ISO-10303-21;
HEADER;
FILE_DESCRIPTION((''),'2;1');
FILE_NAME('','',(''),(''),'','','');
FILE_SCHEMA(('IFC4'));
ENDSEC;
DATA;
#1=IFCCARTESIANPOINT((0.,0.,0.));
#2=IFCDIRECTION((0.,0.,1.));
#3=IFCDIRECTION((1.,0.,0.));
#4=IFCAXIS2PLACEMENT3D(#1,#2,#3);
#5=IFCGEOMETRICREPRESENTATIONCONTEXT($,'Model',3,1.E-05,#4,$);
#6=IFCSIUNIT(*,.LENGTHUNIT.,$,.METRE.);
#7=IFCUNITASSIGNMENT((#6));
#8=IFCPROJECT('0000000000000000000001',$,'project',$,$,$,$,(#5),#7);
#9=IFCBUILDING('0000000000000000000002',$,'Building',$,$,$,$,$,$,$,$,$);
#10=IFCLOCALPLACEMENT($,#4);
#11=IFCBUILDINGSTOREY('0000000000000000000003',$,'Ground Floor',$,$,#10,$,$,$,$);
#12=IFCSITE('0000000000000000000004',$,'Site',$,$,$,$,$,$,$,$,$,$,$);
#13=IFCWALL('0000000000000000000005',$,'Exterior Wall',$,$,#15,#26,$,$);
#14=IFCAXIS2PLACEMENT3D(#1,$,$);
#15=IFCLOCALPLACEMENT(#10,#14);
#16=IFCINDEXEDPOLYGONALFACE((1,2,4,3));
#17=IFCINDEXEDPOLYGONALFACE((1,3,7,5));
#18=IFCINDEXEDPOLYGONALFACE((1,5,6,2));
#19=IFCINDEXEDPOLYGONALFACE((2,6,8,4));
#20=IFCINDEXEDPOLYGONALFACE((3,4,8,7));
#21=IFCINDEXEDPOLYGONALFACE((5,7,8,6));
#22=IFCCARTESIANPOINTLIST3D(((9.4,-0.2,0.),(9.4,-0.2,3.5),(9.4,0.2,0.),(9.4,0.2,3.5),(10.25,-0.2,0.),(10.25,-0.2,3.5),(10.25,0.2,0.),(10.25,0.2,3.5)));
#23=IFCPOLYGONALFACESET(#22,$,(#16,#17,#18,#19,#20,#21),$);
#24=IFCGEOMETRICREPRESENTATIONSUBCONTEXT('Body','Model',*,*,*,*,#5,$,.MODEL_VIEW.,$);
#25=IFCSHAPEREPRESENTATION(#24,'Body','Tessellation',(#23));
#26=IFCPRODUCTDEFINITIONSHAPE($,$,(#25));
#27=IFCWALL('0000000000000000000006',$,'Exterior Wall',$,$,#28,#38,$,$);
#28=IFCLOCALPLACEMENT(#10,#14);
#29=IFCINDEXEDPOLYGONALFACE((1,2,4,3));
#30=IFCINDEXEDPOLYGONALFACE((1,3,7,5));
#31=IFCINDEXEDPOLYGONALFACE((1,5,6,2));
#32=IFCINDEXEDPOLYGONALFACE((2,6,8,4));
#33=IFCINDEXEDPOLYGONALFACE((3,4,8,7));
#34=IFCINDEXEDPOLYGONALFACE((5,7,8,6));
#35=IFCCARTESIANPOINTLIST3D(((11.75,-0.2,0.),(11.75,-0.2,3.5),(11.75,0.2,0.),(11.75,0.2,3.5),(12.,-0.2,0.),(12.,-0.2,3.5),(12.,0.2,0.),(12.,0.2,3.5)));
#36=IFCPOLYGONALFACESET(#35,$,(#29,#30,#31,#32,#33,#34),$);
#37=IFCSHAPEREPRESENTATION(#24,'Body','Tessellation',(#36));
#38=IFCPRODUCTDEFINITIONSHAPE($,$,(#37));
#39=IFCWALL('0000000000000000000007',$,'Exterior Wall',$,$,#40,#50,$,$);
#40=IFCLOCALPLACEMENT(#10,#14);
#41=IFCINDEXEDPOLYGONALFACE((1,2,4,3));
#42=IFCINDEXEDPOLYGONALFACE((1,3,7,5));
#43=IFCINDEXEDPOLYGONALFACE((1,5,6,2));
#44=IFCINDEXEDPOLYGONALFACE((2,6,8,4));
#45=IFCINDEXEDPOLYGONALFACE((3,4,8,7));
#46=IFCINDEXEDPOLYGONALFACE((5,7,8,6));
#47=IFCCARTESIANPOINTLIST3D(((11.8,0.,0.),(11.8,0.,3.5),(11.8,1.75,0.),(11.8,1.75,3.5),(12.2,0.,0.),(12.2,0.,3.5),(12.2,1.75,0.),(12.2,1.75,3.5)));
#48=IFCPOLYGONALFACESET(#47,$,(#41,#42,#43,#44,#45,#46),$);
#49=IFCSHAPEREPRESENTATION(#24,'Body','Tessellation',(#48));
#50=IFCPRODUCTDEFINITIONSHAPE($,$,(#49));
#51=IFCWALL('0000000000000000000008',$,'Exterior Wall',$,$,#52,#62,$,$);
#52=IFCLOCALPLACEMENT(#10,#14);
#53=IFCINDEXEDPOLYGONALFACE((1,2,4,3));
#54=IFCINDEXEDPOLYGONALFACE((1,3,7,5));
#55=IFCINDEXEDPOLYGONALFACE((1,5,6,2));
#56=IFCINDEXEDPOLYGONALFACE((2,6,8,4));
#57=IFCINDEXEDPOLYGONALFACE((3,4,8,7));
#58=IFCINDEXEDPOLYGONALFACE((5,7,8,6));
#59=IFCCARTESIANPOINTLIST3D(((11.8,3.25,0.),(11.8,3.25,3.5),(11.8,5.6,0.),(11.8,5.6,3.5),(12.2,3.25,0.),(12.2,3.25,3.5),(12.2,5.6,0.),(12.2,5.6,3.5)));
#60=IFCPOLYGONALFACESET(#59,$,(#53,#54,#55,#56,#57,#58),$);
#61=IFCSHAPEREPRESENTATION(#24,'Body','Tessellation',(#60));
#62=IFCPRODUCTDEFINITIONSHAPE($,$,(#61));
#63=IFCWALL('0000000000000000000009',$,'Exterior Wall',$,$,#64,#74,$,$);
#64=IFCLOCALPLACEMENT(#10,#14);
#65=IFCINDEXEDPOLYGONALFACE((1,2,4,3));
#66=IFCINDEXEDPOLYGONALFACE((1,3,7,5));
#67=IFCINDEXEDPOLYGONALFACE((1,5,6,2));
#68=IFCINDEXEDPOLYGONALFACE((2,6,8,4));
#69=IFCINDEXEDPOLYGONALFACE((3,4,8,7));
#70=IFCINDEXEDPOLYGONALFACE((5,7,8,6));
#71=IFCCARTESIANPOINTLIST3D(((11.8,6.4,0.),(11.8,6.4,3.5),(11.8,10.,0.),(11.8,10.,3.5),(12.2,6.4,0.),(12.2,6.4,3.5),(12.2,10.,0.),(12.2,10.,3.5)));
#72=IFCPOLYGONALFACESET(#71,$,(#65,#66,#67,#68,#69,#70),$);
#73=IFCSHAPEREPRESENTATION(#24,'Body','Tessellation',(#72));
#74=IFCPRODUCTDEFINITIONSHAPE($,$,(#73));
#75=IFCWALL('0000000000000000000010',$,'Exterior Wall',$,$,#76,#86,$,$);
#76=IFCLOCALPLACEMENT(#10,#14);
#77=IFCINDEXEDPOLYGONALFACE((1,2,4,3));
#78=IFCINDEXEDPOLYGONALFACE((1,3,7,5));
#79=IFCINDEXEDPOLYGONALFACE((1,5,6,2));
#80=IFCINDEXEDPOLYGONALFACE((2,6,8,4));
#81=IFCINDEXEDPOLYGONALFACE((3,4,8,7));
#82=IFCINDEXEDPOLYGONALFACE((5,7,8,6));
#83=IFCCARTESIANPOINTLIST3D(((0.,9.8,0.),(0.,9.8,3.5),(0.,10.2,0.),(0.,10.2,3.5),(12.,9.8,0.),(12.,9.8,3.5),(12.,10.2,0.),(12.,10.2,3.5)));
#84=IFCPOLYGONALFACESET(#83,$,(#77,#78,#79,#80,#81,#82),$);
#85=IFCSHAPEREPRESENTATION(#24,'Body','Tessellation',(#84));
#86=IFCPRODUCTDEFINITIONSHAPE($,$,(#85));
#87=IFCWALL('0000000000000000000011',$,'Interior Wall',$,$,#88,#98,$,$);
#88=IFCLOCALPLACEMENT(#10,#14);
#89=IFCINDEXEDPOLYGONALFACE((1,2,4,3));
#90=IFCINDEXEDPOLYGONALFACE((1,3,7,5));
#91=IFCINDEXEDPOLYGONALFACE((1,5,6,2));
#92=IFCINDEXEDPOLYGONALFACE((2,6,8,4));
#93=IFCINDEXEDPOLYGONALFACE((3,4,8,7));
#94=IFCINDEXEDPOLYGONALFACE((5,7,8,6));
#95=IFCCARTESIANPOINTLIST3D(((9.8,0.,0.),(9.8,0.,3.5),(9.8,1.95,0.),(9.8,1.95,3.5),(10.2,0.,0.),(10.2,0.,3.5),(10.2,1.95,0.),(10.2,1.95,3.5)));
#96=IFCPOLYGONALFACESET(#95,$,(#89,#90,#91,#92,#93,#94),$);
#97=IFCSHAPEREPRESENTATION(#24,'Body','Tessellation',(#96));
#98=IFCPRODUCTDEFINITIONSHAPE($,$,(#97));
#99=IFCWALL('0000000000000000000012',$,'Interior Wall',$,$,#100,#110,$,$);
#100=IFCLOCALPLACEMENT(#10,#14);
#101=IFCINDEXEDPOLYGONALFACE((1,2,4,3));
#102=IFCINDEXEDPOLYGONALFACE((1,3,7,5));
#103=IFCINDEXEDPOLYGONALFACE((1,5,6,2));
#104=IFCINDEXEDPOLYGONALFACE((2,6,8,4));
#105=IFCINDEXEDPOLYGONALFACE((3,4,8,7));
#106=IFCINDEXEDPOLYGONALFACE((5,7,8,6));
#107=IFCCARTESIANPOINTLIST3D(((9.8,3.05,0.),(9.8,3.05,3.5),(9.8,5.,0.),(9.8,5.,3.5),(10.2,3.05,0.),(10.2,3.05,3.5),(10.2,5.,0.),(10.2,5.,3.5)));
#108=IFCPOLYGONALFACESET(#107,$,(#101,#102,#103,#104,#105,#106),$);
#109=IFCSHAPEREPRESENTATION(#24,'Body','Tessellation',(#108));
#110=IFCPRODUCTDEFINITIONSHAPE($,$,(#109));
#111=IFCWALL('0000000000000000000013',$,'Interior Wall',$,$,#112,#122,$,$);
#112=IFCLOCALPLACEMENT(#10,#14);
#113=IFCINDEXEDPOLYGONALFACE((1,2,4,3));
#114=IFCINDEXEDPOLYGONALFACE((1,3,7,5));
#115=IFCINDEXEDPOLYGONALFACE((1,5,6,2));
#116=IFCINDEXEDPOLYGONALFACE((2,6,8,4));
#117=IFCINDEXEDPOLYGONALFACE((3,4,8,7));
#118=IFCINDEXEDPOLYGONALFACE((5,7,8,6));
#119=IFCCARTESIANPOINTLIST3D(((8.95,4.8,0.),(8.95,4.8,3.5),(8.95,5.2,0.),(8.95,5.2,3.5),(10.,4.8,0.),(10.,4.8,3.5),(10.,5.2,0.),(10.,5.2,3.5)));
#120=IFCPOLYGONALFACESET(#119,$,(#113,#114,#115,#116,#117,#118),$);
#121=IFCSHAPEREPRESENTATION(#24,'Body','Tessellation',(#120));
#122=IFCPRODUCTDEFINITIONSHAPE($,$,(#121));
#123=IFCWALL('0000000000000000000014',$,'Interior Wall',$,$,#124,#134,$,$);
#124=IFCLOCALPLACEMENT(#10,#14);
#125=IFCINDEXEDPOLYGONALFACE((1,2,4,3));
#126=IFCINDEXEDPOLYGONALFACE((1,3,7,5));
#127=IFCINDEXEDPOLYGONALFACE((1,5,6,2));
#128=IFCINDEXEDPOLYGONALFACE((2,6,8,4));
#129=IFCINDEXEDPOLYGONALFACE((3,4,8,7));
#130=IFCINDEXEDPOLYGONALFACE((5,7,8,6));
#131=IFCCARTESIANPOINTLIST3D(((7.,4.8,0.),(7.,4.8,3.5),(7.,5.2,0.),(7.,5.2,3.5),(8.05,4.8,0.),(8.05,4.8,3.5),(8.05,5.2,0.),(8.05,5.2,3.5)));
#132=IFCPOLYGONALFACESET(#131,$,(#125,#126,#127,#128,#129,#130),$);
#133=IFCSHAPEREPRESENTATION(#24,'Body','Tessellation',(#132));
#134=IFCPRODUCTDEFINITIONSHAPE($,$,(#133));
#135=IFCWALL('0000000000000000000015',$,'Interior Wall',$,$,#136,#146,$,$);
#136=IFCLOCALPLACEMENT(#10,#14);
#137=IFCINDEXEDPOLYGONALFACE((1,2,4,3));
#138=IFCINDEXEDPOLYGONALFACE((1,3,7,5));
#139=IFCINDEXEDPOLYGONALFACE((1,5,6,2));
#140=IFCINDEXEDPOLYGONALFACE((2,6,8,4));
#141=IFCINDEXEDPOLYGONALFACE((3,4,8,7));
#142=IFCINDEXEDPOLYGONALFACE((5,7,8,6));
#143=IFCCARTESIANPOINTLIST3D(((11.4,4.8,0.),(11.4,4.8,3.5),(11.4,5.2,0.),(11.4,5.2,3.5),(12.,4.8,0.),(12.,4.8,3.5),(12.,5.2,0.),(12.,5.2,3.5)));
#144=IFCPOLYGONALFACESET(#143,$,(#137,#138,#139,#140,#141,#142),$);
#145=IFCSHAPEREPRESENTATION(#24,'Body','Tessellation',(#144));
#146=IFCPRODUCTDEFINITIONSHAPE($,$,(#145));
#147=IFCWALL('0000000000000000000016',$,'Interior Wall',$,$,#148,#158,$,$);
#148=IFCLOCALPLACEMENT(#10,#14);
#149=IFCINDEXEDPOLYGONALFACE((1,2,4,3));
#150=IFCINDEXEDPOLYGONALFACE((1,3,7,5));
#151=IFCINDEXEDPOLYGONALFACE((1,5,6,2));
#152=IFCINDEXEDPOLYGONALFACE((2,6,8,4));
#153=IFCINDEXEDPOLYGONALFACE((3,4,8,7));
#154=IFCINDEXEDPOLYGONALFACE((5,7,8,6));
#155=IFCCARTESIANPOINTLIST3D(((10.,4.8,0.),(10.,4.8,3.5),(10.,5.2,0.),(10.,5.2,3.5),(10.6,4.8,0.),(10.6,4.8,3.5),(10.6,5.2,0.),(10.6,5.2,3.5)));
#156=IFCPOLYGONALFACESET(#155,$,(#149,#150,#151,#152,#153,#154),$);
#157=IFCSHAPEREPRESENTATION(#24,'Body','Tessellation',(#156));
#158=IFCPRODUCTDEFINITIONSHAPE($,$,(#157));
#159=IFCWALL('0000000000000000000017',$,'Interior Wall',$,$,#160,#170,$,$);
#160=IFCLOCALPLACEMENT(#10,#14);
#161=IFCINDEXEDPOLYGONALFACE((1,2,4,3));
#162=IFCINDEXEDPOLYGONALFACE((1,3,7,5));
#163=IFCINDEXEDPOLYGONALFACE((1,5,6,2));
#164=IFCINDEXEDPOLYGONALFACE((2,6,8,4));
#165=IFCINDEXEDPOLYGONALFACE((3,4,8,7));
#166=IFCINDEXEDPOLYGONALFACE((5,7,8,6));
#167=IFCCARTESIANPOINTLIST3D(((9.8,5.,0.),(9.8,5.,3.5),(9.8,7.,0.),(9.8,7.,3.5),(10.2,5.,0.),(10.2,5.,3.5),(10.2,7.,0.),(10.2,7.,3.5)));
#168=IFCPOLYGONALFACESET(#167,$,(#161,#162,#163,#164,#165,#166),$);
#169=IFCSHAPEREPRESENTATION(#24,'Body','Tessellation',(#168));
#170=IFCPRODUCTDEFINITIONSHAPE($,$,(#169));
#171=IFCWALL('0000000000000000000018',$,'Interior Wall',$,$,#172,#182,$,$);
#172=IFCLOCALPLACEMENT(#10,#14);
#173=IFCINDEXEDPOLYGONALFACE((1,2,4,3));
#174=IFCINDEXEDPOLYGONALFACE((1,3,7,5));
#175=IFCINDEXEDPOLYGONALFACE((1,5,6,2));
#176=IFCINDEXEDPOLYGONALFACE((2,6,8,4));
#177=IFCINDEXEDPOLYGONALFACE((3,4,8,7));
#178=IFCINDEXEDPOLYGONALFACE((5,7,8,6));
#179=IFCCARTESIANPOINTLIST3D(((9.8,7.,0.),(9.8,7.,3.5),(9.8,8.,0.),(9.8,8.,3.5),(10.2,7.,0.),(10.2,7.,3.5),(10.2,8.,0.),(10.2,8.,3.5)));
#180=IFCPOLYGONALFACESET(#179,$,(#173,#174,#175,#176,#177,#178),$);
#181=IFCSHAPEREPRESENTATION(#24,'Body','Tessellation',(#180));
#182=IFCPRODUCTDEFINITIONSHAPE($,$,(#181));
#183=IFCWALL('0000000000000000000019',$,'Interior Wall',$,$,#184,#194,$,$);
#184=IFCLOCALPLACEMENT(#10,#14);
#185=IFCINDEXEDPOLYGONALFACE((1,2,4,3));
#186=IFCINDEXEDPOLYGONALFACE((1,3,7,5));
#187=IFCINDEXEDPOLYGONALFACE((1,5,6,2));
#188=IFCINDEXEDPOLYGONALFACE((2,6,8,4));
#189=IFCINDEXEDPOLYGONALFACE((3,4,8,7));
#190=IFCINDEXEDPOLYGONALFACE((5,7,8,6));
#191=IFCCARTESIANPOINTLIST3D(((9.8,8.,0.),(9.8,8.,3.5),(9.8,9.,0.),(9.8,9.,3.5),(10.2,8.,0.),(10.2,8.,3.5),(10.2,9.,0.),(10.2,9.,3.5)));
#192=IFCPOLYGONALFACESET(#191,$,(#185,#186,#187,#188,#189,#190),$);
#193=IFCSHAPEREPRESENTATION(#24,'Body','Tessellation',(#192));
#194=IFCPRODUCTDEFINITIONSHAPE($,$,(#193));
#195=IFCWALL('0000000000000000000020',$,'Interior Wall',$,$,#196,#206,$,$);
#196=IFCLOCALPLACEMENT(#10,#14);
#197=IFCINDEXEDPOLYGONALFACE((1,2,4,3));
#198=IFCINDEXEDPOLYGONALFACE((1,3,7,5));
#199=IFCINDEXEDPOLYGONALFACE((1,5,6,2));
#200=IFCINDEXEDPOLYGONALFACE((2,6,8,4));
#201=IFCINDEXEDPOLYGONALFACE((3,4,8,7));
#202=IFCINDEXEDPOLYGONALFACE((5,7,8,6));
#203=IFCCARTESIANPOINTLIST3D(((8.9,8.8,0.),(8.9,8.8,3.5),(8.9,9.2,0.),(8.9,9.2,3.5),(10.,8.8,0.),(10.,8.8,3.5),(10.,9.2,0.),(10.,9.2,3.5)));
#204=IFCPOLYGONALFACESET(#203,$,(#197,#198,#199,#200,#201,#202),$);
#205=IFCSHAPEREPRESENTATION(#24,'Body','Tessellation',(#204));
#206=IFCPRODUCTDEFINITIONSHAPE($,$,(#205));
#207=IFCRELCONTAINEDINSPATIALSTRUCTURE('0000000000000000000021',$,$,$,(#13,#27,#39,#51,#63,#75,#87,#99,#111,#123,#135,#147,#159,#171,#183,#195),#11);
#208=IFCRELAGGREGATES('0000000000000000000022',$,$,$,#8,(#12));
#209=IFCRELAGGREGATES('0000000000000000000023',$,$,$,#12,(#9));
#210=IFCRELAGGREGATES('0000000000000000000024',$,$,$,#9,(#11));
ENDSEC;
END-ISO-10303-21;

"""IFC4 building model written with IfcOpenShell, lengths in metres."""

from ifc_helpers import new_model, si_unit, frame, origin_with_axes, place, context, subcontext, project, spatial, indexed_curve, outline, extrude, element, save


model = new_model("IFC4")

# Units and contexts
model_context = context("Model", 3, precision=1e-05, world=origin_with_axes())
body_context = subcontext(model_context, "Body", "Model", "MODEL_VIEW")
ifc_project = project(units=[si_unit("LENGTHUNIT", "METRE")], contexts=[model_context])

# Site, building, storey
site = spatial("IfcSite", under=ifc_project, Name="Site")
building = spatial("IfcBuilding", under=site, Name="Building")
storey_placement = place(None, origin_with_axes())
storey = spatial("IfcBuildingStorey", under=building, at=storey_placement, Name="Ground Floor")

# Walls
wall_1_placement = place(storey_placement, frame((9.4, 0.0, 0.0), z_axis=(0.0, 0.0, 1.0), x_axis=(1.0, 0.0, 0.0)))
element("IfcWall", 1, at=wall_1_placement, inside=storey, Name="Exterior Wall", context=body_context, shape_type="SweptSolid", body=[
    extrude(outline(indexed_curve([(0.0, 0.0), (0.0, 0.4), (0.85, 0.4), (0.85, 0.0), (0.0, 0.0)], self_intersect=False)), frame((0.0, -0.2, 0.0), z_axis=(0.0, 0.0, 1.0), x_axis=(1.0, 0.0, 0.0)), (0.0, 0.0, 1.0), 3.5),
])
wall_2_placement = place(storey_placement, frame((11.75, 0.0, 0.0), z_axis=(0.0, 0.0, 1.0), x_axis=(1.0, 0.0, 0.0)))
element("IfcWall", 2, at=wall_2_placement, inside=storey, Name="Exterior Wall", context=body_context, shape_type="SweptSolid", body=[
    extrude(outline(indexed_curve([(0.0, 0.0), (0.0, 0.4), (0.25, 0.4), (0.25, 0.0), (0.0, 0.0)], self_intersect=False)), frame((0.0, -0.2, 0.0), z_axis=(0.0, 0.0, 1.0), x_axis=(1.0, 0.0, 0.0)), (0.0, 0.0, 1.0), 3.5),
])
wall_3_placement = place(storey_placement, frame((12.0, 0.0, 0.0), z_axis=(0.0, 0.0, 1.0), x_axis=(0.0, 1.0, 0.0)))
element("IfcWall", 3, at=wall_3_placement, inside=storey, Name="Exterior Wall", context=body_context, shape_type="SweptSolid", body=[
    extrude(outline(indexed_curve([(0.0, 0.0), (0.0, 0.4), (1.75, 0.4), (1.75, 0.0), (0.0, 0.0)], self_intersect=False)), frame((0.0, -0.2, 0.0), z_axis=(0.0, 0.0, 1.0), x_axis=(1.0, 0.0, 0.0)), (0.0, 0.0, 1.0), 3.5),
])
wall_4_placement = place(storey_placement, frame((12.0, 3.25, 0.0), z_axis=(0.0, 0.0, 1.0), x_axis=(0.0, 1.0, 0.0)))
element("IfcWall", 4, at=wall_4_placement, inside=storey, Name="Exterior Wall", context=body_context, shape_type="SweptSolid", body=[
    extrude(outline(indexed_curve([(0.0, 0.0), (0.0, 0.4), (2.35, 0.4), (2.35, 0.0), (0.0, 0.0)], self_intersect=False)), frame((0.0, -0.2, 0.0), z_axis=(0.0, 0.0, 1.0), x_axis=(1.0, 0.0, 0.0)), (0.0, 0.0, 1.0), 3.5),
])
wall_5_placement = place(storey_placement, frame((12.0, 6.4, 0.0), z_axis=(0.0, 0.0, 1.0), x_axis=(0.0, 1.0, 0.0)))
element("IfcWall", 5, at=wall_5_placement, inside=storey, Name="Exterior Wall", context=body_context, shape_type="SweptSolid", body=[
    extrude(outline(indexed_curve([(0.0, 0.0), (0.0, 0.4), (3.6, 0.4), (3.6, 0.0), (0.0, 0.0)], self_intersect=False)), frame((0.0, -0.2, 0.0), z_axis=(0.0, 0.0, 1.0), x_axis=(1.0, 0.0, 0.0)), (0.0, 0.0, 1.0), 3.5),
])
wall_6_placement = place(storey_placement, frame((12.0, 10.0, 0.0), z_axis=(0.0, 0.0, 1.0), x_axis=(-1.0, 0.0, 0.0)))
element("IfcWall", 6, at=wall_6_placement, inside=storey, Name="Exterior Wall", context=body_context, shape_type="SweptSolid", body=[
    extrude(outline(indexed_curve([(0.0, 0.0), (0.0, 0.4), (12.0, 0.4), (12.0, 0.0), (0.0, 0.0)], self_intersect=False)), frame((0.0, -0.2, 0.0), z_axis=(0.0, 0.0, 1.0), x_axis=(1.0, 0.0, 0.0)), (0.0, 0.0, 1.0), 3.5),
])
wall_7_placement = place(storey_placement, frame((10.0, 0.0, 0.0), z_axis=(0.0, 0.0, 1.0), x_axis=(0.0, 1.0, 0.0)))
element("IfcWall", 7, at=wall_7_placement, inside=storey, Name="Interior Wall", context=body_context, shape_type="SweptSolid", body=[
    extrude(outline(indexed_curve([(0.0, 0.0), (0.0, 0.4), (1.95, 0.4), (1.95, 0.0), (0.0, 0.0)], self_intersect=False)), frame((0.0, -0.2, 0.0), z_axis=(0.0, 0.0, 1.0), x_axis=(1.0, 0.0, 0.0)), (0.0, 0.0, 1.0), 3.5),
])
wall_8_placement = place(storey_placement, frame((10.0, 3.05, 0.0), z_axis=(0.0, 0.0, 1.0), x_axis=(0.0, 1.0, 0.0)))
element("IfcWall", 8, at=wall_8_placement, inside=storey, Name="Interior Wall", context=body_context, shape_type="SweptSolid", body=[
    extrude(outline(indexed_curve([(0.0, 0.0), (0.0, 0.4), (1.95, 0.4), (1.95, 0.0), (0.0, 0.0)], self_intersect=False)), frame((0.0, -0.2, 0.0), z_axis=(0.0, 0.0, 1.0), x_axis=(1.0, 0.0, 0.0)), (0.0, 0.0, 1.0), 3.5),
])
for number, where, z_axis, x_axis, name in (
    (9, (10.0, 5.0, 0.0), (0.0, 0.0, 1.0), (-1.0, 0.0, 0.0), "Interior Wall"),
    (10, (8.05, 5.0, 0.0), (0.0, 0.0, 1.0), (-1.0, 0.0, 0.0), "Interior Wall"),
):
    element("IfcWall", number, at=place(storey_placement, frame(where, z_axis=z_axis, x_axis=x_axis)), inside=storey, Name=name, context=body_context, shape_type="SweptSolid", body=[
        extrude(outline(indexed_curve([(0.0, 0.0), (0.0, 0.4), (1.05, 0.4), (1.05, 0.0), (0.0, 0.0)], self_intersect=False)), frame((0.0, -0.2, 0.0), z_axis=(0.0, 0.0, 1.0), x_axis=(1.0, 0.0, 0.0)), (0.0, 0.0, 1.0), 3.5),
    ])
for number, where, z_axis, x_axis, name in (
    (11, (12.0, 5.0, 0.0), (0.0, 0.0, 1.0), (-1.0, 0.0, 0.0), "Interior Wall"),
    (12, (10.6, 5.0, 0.0), (0.0, 0.0, 1.0), (-1.0, 0.0, 0.0), "Interior Wall"),
):
    element("IfcWall", number, at=place(storey_placement, frame(where, z_axis=z_axis, x_axis=x_axis)), inside=storey, Name=name, context=body_context, shape_type="SweptSolid", body=[
        extrude(outline(indexed_curve([(0.0, 0.0), (0.0, 0.4), (0.6, 0.4), (0.6, 0.0), (0.0, 0.0)], self_intersect=False)), frame((0.0, -0.2, 0.0), z_axis=(0.0, 0.0, 1.0), x_axis=(1.0, 0.0, 0.0)), (0.0, 0.0, 1.0), 3.5),
    ])
wall_9_placement = place(storey_placement, frame((10.0, 5.0, 0.0), z_axis=(0.0, 0.0, 1.0), x_axis=(0.0, 1.0, 0.0)))
element("IfcWall", 13, at=wall_9_placement, inside=storey, Name="Interior Wall", context=body_context, shape_type="SweptSolid", body=[
    extrude(outline(indexed_curve([(0.0, 0.0), (0.0, 0.4), (2.0, 0.4), (2.0, 0.0), (0.0, 0.0)], self_intersect=False)), frame((0.0, -0.2, 0.0), z_axis=(0.0, 0.0, 1.0), x_axis=(1.0, 0.0, 0.0)), (0.0, 0.0, 1.0), 3.5),
])
for number, where, z_axis, x_axis, name in (
    (14, (10.0, 7.0, 0.0), (0.0, 0.0, 1.0), (0.0, 1.0, 0.0), "Interior Wall"),
    (15, (10.0, 8.0, 0.0), (0.0, 0.0, 1.0), (0.0, 1.0, 0.0), "Interior Wall"),
):
    element("IfcWall", number, at=place(storey_placement, frame(where, z_axis=z_axis, x_axis=x_axis)), inside=storey, Name=name, context=body_context, shape_type="SweptSolid", body=[
        extrude(outline(indexed_curve([(0.0, 0.0), (0.0, 0.4), (1.0, 0.4), (1.0, 0.0), (0.0, 0.0)], self_intersect=False)), frame((0.0, -0.2, 0.0), z_axis=(0.0, 0.0, 1.0), x_axis=(1.0, 0.0, 0.0)), (0.0, 0.0, 1.0), 3.5),
    ])
for number, where, z_axis, x_axis, name in (
    (16, (10.0, 9.0, 0.0), (0.0, 0.0, 1.0), (-1.0, 0.0, 0.0), "Interior Wall"),
):
    element("IfcWall", number, at=place(storey_placement, frame(where, z_axis=z_axis, x_axis=x_axis)), inside=storey, Name=name, context=body_context, shape_type="SweptSolid", body=[
        extrude(outline(indexed_curve([(0.0, 0.0), (0.0, 0.4), (1.1, 0.4), (1.1, 0.0), (0.0, 0.0)], self_intersect=False)), frame((0.0, -0.2, 0.0), z_axis=(0.0, 0.0, 1.0), x_axis=(1.0, 0.0, 0.0)), (0.0, 0.0, 1.0), 3.5),
    ])

save(model, "model.ifc")
